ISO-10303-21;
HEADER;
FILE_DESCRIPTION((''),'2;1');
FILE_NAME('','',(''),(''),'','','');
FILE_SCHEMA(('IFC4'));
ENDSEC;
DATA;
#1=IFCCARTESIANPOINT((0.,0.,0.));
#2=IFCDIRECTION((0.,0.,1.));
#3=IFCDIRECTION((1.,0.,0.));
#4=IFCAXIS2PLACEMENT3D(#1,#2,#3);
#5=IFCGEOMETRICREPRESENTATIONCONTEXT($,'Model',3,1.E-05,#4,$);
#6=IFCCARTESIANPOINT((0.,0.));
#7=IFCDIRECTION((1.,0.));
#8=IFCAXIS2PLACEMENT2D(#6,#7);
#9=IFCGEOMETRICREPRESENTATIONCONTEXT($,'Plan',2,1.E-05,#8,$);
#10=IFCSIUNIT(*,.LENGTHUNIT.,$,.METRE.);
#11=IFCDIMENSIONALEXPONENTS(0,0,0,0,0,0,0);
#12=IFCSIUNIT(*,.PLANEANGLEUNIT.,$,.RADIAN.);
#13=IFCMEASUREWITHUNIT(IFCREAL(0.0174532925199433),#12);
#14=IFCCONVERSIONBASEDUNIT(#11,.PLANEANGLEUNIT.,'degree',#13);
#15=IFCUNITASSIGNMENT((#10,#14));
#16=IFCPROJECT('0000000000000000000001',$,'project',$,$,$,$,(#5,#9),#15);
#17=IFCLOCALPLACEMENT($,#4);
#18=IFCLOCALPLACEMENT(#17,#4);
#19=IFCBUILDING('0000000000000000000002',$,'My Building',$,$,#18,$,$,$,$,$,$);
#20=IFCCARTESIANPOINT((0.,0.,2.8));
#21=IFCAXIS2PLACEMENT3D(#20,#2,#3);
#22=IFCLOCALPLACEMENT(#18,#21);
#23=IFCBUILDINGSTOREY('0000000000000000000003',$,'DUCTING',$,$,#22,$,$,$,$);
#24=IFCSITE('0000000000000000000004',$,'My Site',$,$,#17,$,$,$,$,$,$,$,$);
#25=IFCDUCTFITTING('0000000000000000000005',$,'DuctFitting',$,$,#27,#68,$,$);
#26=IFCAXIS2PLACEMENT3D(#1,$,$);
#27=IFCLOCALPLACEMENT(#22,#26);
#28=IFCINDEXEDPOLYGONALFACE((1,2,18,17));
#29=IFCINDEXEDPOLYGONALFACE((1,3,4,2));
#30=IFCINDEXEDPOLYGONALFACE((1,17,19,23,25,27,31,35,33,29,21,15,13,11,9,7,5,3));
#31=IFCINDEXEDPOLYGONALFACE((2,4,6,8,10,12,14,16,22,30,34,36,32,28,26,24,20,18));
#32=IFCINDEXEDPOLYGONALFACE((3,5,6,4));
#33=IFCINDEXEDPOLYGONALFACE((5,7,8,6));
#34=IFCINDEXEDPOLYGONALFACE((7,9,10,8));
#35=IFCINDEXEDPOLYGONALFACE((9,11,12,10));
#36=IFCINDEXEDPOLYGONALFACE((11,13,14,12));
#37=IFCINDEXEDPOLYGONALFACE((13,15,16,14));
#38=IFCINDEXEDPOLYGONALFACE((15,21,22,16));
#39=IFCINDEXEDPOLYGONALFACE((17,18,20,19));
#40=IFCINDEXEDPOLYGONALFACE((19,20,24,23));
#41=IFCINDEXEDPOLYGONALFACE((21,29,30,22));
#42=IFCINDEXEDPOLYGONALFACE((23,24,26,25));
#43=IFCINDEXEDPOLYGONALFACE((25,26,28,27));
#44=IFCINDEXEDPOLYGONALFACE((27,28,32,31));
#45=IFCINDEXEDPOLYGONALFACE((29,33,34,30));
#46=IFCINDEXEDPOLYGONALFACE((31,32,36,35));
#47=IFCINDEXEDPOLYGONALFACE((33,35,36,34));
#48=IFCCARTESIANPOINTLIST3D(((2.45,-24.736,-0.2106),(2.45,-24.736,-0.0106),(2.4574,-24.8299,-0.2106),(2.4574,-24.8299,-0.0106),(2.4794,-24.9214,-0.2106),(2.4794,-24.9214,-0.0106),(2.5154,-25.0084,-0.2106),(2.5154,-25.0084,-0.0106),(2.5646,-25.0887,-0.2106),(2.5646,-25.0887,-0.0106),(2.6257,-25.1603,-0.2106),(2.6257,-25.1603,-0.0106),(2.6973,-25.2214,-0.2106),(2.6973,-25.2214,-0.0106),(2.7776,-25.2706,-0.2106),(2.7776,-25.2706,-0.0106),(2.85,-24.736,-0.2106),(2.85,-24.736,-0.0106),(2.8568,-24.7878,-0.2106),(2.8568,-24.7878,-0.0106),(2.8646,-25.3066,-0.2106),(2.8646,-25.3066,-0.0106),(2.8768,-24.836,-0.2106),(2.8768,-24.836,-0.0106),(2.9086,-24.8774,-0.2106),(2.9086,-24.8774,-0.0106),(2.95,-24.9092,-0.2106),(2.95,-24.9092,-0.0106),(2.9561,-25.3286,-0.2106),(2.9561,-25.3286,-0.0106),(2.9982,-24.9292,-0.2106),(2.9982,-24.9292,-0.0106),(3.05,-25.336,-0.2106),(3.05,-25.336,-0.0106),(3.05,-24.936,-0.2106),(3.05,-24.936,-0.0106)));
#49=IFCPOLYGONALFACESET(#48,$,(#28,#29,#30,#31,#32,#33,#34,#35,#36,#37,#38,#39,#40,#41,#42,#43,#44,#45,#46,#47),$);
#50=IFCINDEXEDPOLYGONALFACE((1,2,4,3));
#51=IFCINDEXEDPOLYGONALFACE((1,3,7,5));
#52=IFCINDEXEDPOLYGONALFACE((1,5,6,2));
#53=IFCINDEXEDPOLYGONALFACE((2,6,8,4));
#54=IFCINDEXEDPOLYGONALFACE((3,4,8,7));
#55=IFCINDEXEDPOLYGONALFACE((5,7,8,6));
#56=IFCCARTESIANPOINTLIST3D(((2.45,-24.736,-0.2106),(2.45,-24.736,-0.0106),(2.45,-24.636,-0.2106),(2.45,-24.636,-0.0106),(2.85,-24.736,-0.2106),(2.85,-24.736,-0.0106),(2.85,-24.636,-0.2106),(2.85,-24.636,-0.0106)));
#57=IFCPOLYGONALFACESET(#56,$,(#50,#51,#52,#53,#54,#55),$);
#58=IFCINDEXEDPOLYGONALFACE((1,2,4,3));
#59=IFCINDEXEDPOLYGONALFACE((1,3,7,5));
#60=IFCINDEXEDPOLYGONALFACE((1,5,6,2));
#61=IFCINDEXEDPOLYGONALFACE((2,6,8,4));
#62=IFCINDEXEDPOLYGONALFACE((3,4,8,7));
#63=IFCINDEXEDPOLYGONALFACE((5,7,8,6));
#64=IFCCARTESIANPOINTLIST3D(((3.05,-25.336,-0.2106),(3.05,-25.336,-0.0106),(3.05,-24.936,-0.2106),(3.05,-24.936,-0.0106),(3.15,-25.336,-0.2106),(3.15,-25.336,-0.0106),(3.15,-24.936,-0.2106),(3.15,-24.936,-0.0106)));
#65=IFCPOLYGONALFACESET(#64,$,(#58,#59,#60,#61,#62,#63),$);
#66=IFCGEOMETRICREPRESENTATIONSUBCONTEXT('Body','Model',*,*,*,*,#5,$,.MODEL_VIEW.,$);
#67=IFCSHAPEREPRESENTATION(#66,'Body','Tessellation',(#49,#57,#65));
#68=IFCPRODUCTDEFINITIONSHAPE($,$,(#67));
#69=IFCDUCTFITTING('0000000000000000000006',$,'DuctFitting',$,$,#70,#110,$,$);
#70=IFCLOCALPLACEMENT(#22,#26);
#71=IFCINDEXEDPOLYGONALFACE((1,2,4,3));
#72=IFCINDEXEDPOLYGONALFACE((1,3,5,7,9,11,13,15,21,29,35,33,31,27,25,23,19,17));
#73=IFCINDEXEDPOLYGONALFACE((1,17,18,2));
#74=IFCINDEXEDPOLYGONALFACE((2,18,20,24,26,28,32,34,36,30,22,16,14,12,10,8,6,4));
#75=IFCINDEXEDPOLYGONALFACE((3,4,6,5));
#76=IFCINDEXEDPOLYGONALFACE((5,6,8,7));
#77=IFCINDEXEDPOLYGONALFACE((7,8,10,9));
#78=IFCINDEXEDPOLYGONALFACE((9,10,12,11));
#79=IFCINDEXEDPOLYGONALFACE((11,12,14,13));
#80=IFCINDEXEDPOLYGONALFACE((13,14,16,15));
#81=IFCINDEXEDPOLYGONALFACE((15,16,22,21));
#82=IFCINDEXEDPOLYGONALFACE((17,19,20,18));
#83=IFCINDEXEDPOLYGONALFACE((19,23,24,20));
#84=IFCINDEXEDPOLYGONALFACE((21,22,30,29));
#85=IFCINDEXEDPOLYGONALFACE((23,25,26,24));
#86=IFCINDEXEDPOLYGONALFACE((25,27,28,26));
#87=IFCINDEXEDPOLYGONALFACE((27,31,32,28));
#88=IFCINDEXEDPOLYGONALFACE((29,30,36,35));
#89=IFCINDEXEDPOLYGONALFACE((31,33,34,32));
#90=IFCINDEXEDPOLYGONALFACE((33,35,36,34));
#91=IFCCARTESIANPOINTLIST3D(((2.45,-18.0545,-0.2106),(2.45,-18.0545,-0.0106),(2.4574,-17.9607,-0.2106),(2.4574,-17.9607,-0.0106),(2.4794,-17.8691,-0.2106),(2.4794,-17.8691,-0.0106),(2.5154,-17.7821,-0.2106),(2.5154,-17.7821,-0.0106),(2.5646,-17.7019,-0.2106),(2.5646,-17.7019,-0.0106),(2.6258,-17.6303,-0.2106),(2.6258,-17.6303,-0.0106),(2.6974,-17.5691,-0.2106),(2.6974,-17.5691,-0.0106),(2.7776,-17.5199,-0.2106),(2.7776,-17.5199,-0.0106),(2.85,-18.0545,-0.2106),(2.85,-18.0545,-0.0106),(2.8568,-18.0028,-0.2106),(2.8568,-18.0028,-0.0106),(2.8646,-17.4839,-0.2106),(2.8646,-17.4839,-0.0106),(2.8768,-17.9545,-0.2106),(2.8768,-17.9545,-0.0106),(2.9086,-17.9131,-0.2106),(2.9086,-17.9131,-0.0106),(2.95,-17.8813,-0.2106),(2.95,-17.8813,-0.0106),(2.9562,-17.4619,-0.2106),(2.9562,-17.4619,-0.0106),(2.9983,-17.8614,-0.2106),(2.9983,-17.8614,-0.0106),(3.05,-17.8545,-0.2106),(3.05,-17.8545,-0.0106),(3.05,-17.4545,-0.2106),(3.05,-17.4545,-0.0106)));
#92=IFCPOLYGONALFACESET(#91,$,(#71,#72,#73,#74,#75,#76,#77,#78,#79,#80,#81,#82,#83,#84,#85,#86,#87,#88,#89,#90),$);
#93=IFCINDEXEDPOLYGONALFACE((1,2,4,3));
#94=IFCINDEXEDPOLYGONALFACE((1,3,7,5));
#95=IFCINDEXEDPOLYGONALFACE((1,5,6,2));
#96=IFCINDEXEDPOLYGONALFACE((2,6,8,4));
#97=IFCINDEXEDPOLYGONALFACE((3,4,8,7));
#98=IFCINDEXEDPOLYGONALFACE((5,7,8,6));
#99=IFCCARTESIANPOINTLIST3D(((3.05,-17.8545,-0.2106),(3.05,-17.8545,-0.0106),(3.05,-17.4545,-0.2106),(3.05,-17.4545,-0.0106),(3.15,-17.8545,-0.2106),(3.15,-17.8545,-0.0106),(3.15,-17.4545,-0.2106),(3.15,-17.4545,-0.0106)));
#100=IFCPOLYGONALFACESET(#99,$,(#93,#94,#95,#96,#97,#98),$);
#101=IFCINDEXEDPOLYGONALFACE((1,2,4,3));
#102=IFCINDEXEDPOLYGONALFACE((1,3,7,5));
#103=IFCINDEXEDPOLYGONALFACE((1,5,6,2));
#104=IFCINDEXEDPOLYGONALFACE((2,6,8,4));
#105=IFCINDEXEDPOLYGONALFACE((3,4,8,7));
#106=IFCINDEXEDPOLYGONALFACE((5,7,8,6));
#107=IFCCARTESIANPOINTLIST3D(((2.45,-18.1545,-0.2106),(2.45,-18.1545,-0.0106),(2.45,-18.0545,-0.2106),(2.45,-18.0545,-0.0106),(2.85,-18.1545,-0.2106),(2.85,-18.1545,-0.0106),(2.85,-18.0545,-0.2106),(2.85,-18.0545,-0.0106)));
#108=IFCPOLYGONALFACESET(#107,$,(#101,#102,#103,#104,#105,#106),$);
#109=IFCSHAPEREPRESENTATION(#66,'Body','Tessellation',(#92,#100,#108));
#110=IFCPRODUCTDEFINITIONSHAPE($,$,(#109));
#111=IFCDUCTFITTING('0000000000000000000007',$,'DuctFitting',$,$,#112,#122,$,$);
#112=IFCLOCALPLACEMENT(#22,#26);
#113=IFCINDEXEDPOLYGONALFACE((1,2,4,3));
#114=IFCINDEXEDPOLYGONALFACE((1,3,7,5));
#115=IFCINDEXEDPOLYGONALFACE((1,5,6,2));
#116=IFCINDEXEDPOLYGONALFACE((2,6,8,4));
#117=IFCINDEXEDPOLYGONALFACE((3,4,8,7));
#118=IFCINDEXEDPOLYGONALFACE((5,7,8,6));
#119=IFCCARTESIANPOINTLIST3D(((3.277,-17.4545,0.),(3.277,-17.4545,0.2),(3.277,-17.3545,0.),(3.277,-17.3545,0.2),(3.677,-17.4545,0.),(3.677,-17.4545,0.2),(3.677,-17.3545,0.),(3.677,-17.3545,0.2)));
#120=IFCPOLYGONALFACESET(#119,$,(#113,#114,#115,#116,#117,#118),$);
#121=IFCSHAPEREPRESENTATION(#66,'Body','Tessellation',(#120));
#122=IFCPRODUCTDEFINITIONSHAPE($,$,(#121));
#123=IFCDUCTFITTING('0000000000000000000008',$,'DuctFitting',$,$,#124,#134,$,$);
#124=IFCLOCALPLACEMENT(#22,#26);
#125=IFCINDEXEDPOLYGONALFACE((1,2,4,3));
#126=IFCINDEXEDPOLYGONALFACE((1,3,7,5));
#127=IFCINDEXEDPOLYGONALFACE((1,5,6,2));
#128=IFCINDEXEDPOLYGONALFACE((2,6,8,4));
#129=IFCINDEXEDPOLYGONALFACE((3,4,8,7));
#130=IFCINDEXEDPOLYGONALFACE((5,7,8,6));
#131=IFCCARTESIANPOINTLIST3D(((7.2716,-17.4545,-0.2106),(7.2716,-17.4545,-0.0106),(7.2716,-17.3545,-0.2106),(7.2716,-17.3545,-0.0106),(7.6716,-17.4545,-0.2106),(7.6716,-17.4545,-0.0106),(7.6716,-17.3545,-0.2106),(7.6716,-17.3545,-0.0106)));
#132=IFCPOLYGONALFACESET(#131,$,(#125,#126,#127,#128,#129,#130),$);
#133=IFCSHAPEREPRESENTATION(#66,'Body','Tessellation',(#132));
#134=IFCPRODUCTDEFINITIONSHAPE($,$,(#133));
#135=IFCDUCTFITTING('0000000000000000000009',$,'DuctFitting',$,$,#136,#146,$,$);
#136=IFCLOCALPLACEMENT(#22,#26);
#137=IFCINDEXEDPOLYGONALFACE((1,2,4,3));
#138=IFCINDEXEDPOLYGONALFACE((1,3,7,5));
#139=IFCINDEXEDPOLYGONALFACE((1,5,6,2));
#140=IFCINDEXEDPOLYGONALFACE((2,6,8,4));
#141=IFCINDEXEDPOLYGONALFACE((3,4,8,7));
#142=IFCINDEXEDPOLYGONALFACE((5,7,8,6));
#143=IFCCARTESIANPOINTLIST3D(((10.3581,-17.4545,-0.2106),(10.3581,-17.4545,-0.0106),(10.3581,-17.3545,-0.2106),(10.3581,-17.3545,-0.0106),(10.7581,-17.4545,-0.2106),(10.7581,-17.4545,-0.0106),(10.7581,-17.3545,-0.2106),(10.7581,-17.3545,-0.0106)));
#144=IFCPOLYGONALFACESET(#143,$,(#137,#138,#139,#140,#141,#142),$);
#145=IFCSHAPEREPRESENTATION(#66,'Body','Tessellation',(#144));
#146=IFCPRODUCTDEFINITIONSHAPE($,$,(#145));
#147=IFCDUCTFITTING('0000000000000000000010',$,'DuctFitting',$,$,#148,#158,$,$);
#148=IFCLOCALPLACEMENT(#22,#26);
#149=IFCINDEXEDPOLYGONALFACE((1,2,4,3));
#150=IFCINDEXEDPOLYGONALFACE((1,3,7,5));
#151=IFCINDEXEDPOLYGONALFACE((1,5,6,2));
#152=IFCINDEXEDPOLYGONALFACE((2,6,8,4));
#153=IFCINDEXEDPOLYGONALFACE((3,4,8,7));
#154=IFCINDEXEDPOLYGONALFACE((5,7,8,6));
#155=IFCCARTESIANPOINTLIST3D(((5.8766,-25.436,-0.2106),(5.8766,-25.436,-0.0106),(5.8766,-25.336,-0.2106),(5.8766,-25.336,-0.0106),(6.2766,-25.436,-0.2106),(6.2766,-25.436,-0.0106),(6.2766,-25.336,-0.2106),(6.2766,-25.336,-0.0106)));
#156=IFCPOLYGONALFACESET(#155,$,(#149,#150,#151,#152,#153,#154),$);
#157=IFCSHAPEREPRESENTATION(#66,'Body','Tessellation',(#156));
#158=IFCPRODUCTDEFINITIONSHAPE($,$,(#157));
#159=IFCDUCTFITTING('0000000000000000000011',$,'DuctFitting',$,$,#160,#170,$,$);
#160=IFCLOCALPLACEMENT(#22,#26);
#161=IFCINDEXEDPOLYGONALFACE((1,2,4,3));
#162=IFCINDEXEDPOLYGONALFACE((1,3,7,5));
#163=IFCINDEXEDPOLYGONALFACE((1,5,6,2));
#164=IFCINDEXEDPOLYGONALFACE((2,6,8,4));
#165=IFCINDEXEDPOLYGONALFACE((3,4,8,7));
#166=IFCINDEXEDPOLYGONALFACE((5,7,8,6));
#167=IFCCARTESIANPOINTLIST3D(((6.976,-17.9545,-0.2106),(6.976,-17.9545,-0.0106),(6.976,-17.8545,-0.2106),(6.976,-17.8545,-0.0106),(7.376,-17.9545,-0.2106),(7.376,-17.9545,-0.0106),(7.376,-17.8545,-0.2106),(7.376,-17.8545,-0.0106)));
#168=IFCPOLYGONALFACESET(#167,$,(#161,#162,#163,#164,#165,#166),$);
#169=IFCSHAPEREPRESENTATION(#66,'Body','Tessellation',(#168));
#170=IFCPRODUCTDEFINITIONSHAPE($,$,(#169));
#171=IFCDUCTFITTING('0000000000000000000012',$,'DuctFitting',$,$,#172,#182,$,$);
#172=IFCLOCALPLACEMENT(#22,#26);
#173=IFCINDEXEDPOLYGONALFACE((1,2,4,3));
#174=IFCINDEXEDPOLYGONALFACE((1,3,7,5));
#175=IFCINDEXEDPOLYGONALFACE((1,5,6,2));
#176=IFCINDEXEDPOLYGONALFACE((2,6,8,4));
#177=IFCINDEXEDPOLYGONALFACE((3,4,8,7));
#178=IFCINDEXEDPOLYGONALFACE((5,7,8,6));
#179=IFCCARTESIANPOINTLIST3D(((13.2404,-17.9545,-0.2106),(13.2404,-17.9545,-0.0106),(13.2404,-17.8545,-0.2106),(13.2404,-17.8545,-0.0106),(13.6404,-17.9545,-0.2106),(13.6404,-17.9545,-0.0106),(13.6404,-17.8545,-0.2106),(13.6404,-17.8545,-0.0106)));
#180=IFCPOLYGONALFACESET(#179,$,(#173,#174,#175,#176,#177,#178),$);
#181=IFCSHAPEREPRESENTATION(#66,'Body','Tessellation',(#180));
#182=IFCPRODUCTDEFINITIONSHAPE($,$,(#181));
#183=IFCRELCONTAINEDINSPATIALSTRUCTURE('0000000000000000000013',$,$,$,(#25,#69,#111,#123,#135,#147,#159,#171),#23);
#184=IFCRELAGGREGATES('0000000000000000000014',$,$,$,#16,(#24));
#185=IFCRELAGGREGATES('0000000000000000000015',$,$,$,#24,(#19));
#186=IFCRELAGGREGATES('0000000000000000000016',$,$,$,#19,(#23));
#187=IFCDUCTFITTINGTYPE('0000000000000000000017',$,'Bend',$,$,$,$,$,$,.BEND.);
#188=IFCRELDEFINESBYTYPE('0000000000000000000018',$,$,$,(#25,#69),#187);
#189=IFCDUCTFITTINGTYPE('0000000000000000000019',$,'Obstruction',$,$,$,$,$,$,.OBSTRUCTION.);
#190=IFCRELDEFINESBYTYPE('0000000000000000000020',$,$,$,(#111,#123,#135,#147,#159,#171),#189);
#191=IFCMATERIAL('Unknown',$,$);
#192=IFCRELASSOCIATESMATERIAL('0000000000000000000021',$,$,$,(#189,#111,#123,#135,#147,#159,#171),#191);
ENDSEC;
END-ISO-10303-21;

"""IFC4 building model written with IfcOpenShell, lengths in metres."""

from ifc_helpers import new_model, entity, si_unit, converted_unit, frame, origin_with_axes, origin_2d_with_axis, place, context, subcontext, project, spatial, line, arc, indexed_curve, rectangle, outline, extrude, source, transform, mapped, material, material_profile, profile_set, profile_usage, type_object, type_shapes, element, save


model = new_model("IFC4")

# Units and contexts
model_context = context("Model", 3, precision=1e-05, world=origin_with_axes())
plan_context = context("Plan", 2, precision=1e-05, world=origin_2d_with_axis())
body_context = subcontext(model_context, "Body", "Model", "MODEL_VIEW")
ifc_project = project(units=[si_unit("LENGTHUNIT", "METRE"), converted_unit("PLANEANGLEUNIT", "degree", entity("IfcReal", 0.0174532925199433), si_unit("PLANEANGLEUNIT", "RADIAN"), dimensions=[0, 0, 0, 0, 0, 0, 0])], contexts=[model_context, plan_context])

# Site, building, storey
site_placement = place(None, origin_with_axes())
site = spatial("IfcSite", under=ifc_project, at=site_placement, Name="My Site")
building_placement = place(site_placement, origin_with_axes())
building = spatial("IfcBuilding", under=site, at=building_placement, Name="My Building")
storey_placement = place(building_placement, frame((0.0, 0.0, 2.8), z_axis=(0.0, 0.0, 1.0), x_axis=(1.0, 0.0, 0.0)))
storey = spatial("IfcBuildingStorey", under=building, at=storey_placement, Name="DUCTING")

# Shared definitions
ifc_material = material(Name="Unknown")

# Duct fittings
duct_fitting_type_1 = type_object("IfcDuctFittingType", Name="Bend", PredefinedType="BEND")
shared_shape = source(origin_with_axes(), body_context, "Body", "SweptSolid", [
    extrude(outline(indexed_curve([(-0.2, 0.0), (-0.2586, -0.1414), (-0.4, -0.2), (-0.4, -0.6), (0.0243, -0.4243), (0.2, 0.0)], segments=[arc(1, 2, 3), line(3, 4), arc(4, 5, 6), line(6, 1)])), frame((0.0, -0.1, -0.1), z_axis=(0.0, -1.0, 0.0), x_axis=(1.0, 0.0, 0.0)), (0.0, 0.0, -1.0), 0.2),
    extrude(rectangle(XDim=0.4, YDim=0.2), origin_with_axes(), (0.0, 0.0, -1.0), 0.1),
    extrude(rectangle(XDim=0.4, YDim=0.2), frame((-0.4, 0.0, -0.5), z_axis=(-1.0, 0.0, 0.0), x_axis=(0.0, 0.0, -1.0)), (0.0, 0.0, 1.0), 0.1),
])
type_shapes(duct_fitting_type_1, [shared_shape])
for number, where, z_axis, x_axis, name in (
    (1, (2.65, -24.636, -0.1106), (0.000004, 1.0, 0.000001), (-1.0, 0.000004, 0.0), "DuctFitting"),
    (2, (3.15, -17.6545, -0.1106), (1.0, 0.0, 0.0), (0.0, 1.0, 0.0), "DuctFitting"),
):
    element("IfcDuctFitting", number, at=place(storey_placement, frame(where, z_axis=z_axis, x_axis=x_axis)), inside=storey, type_object=duct_fitting_type_1, Name=name, context=body_context, shape_type="MappedRepresentation", body=[
        mapped(shared_shape, transform((0.0, 0.0, 0.0), x_axis=(1.0, 0.0, 0.0), y_axis=(0.0, 1.0, 0.0), z_axis=(0.0, 0.0, 1.0), scale=1.0)),
    ])
ifc_material_profile_1 = material_profile(ifc_material, rectangle(XDim=0.4, YDim=0.2))
ifc_profile_set_1 = profile_set([ifc_material_profile_1])
ifc_profile_usage_1 = profile_usage(ifc_profile_set_1, cardinal=5)
duct_fitting_type_2 = type_object("IfcDuctFittingType", Name="Obstruction", PredefinedType="OBSTRUCTION", material=ifc_profile_set_1)
duct_fitting_1_placement = place(storey_placement, frame((3.477, -17.4545, 0.1), z_axis=(0.0, 1.0, 0.0), x_axis=(-1.0, 0.0, 0.0)))
element("IfcDuctFitting", 3, at=duct_fitting_1_placement, inside=storey, type_object=duct_fitting_type_2, material=ifc_profile_usage_1, Name="DuctFitting", context=body_context, shape_type="SweptSolid", body=[
    extrude(rectangle(XDim=0.4, YDim=0.2), origin_with_axes(), (0.0, 0.0, 1.0), 0.1),
])
ifc_profile_usage_2 = profile_usage(ifc_profile_set_1, cardinal=5)
duct_fitting_2_placement = place(storey_placement, frame((7.4716, -17.4545, -0.1106), z_axis=(0.0, 1.0, 0.0), x_axis=(-1.0, 0.0, 0.0)))
element("IfcDuctFitting", 4, at=duct_fitting_2_placement, inside=storey, type_object=duct_fitting_type_2, material=ifc_profile_usage_2, Name="DuctFitting", context=body_context, shape_type="SweptSolid", body=[
    extrude(rectangle(XDim=0.4, YDim=0.2), origin_with_axes(), (0.0, 0.0, 1.0), 0.1),
])
ifc_profile_usage_3 = profile_usage(ifc_profile_set_1, cardinal=5)
duct_fitting_3_placement = place(storey_placement, frame((10.5581, -17.4545, -0.1106), z_axis=(0.0, 1.0, 0.0), x_axis=(-1.0, 0.0, 0.0)))
element("IfcDuctFitting", 5, at=duct_fitting_3_placement, inside=storey, type_object=duct_fitting_type_2, material=ifc_profile_usage_3, Name="DuctFitting", context=body_context, shape_type="SweptSolid", body=[
    extrude(rectangle(XDim=0.4, YDim=0.2), origin_with_axes(), (0.0, 0.0, 1.0), 0.1),
])
ifc_profile_usage_4 = profile_usage(ifc_profile_set_1, cardinal=5)
duct_fitting_4_placement = place(storey_placement, frame((6.0766, -25.436, -0.1106), z_axis=(0.0, 1.0, 0.0), x_axis=(-1.0, 0.0, 0.0)))
element("IfcDuctFitting", 6, at=duct_fitting_4_placement, inside=storey, type_object=duct_fitting_type_2, material=ifc_profile_usage_4, Name="DuctFitting", context=body_context, shape_type="SweptSolid", body=[
    extrude(rectangle(XDim=0.4, YDim=0.2), origin_with_axes(), (0.0, 0.0, 1.0), 0.1),
])
ifc_profile_usage_5 = profile_usage(ifc_profile_set_1, cardinal=5)
duct_fitting_5_placement = place(storey_placement, frame((7.176, -17.9545, -0.1106), z_axis=(0.0, 1.0, 0.0), x_axis=(-1.0, 0.0, 0.0)))
element("IfcDuctFitting", 7, at=duct_fitting_5_placement, inside=storey, type_object=duct_fitting_type_2, material=ifc_profile_usage_5, Name="DuctFitting", context=body_context, shape_type="SweptSolid", body=[
    extrude(rectangle(XDim=0.4, YDim=0.2), origin_with_axes(), (0.0, 0.0, 1.0), 0.1),
])
ifc_profile_usage_6 = profile_usage(ifc_profile_set_1, cardinal=5)
duct_fitting_6_placement = place(storey_placement, frame((13.4404, -17.9545, -0.1106), z_axis=(0.0, 1.0, 0.0), x_axis=(-1.0, 0.0, 0.0)))
element("IfcDuctFitting", 8, at=duct_fitting_6_placement, inside=storey, type_object=duct_fitting_type_2, material=ifc_profile_usage_6, Name="DuctFitting", context=body_context, shape_type="SweptSolid", body=[
    extrude(rectangle(XDim=0.4, YDim=0.2), origin_with_axes(), (0.0, 0.0, 1.0), 0.1),
])

save(model, "model.ifc")
